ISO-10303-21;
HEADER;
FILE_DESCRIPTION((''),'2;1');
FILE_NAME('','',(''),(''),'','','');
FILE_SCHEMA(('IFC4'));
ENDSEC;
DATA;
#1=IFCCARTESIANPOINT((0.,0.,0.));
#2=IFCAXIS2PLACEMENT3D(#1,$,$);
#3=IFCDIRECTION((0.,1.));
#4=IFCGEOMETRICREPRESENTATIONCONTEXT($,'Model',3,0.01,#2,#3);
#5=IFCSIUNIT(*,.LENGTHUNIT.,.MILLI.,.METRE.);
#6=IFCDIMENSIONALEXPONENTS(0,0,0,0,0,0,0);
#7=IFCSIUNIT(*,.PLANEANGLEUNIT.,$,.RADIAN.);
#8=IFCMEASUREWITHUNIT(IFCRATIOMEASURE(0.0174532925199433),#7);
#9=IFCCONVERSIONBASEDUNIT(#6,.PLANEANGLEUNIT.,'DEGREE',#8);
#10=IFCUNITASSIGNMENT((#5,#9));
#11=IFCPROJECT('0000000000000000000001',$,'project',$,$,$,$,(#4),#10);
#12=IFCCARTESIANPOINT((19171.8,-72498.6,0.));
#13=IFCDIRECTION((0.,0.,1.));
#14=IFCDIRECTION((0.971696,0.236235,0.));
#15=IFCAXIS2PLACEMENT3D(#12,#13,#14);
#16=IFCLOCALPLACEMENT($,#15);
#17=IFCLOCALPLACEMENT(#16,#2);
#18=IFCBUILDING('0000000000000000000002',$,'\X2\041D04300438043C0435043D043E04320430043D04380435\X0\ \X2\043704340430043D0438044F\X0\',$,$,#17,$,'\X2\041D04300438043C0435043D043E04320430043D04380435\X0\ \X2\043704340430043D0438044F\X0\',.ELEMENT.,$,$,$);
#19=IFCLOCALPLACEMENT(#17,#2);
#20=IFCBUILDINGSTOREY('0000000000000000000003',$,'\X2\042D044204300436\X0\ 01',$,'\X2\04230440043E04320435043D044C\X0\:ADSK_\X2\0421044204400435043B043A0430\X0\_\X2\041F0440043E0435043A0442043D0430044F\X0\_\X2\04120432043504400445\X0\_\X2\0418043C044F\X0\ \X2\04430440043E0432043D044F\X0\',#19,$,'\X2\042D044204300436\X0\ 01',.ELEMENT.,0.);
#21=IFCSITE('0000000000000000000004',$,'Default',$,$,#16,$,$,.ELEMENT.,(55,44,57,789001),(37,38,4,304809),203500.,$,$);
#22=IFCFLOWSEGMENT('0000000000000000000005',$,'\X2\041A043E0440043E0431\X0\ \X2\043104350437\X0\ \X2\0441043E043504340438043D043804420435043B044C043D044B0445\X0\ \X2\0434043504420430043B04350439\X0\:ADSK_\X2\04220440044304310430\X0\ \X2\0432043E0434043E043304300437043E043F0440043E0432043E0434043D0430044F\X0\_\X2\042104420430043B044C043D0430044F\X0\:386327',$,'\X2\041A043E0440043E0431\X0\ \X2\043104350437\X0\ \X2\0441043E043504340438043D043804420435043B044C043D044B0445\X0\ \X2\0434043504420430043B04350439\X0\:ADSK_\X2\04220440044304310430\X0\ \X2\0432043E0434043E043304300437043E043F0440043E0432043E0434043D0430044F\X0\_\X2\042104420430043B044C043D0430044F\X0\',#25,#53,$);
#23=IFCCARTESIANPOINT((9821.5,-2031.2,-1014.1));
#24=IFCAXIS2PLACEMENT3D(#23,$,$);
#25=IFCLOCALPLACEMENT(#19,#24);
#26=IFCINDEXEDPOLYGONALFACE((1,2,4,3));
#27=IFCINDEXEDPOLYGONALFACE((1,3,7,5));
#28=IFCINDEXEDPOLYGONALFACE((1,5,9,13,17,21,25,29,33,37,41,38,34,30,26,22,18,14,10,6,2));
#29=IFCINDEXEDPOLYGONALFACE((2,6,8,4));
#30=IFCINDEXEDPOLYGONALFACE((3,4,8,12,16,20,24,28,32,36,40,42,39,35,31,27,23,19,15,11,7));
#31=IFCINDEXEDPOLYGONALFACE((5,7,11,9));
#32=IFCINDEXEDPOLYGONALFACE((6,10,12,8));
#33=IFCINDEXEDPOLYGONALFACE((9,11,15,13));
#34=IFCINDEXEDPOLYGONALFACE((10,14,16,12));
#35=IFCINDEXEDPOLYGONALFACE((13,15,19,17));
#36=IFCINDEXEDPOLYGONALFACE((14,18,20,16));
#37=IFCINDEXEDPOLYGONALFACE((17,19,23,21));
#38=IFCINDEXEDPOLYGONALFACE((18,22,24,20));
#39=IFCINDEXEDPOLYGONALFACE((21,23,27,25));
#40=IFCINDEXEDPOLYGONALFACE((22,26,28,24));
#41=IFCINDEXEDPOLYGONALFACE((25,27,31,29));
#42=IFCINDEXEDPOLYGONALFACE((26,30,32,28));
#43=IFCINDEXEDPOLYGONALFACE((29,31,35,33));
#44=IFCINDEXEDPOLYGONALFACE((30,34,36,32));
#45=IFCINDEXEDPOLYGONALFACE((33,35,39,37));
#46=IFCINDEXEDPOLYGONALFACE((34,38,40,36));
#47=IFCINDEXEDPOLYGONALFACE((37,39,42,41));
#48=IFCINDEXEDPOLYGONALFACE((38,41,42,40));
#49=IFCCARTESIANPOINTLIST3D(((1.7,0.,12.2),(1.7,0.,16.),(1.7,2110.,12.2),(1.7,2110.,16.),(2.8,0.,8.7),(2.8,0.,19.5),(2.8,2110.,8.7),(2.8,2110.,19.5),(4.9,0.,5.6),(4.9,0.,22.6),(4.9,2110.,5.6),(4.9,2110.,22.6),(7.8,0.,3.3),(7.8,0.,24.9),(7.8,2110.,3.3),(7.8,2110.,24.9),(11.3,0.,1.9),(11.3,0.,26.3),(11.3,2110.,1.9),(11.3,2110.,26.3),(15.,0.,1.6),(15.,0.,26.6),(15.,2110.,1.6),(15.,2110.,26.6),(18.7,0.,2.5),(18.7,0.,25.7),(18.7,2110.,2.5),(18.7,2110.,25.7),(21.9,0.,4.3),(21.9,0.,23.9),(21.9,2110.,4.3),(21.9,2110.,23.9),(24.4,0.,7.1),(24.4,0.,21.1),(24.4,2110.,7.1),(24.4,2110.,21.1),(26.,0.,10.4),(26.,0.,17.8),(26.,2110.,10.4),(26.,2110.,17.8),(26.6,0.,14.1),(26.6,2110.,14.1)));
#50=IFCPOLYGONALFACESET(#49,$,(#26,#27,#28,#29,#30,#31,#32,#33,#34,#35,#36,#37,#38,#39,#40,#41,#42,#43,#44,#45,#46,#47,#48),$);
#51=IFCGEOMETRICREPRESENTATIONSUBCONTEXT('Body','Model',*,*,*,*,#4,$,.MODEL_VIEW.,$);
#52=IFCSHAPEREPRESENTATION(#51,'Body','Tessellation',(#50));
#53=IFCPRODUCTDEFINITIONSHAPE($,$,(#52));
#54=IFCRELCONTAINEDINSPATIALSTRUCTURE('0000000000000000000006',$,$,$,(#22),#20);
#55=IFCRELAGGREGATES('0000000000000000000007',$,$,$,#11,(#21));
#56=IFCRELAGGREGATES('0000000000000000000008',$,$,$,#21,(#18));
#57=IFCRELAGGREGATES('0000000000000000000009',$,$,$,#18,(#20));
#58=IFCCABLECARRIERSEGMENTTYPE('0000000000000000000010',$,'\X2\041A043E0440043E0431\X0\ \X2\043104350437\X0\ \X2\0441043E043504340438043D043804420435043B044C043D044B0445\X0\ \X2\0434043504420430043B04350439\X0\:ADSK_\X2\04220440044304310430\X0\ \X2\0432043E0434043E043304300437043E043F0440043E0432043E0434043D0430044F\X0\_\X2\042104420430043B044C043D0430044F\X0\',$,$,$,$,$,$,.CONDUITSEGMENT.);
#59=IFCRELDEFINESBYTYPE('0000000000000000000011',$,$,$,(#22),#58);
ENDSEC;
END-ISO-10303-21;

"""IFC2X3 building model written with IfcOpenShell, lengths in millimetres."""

from ifc_helpers import new_model, entity, si_unit, converted_unit, direction, frame, origin, origin_2d_with_axis, place, context, subcontext, project, spatial, circle, extrude, type_object, element, save


model = new_model("IFC2X3")

# Units and contexts
model_context = context("Model", 3, precision=0.01, world=origin(), true_north=direction((0.0, 1.0)))
body_context = subcontext(model_context, "Body", "Model", "MODEL_VIEW")
ifc_project = project(units=[si_unit("LENGTHUNIT", "METRE", prefix="MILLI"), converted_unit("PLANEANGLEUNIT", "DEGREE", entity("IfcRatioMeasure", 0.0174532925199433), si_unit("PLANEANGLEUNIT", "RADIAN"), dimensions=[0, 0, 0, 0, 0, 0, 0])], contexts=[model_context])

# Site, building, storey
site_placement = place(None, frame((19171.8, -72498.6, 0.0), z_axis=(0.0, 0.0, 1.0), x_axis=(0.971696, 0.236235, 0.0)))
site = spatial("IfcSite", under=ifc_project, at=site_placement, Name="Default", CompositionType="ELEMENT", RefLatitude=(55, 44, 57, 789001), RefLongitude=(37, 38, 4, 304809), RefElevation=203500.0)
building_placement = place(site_placement, origin())
building = spatial("IfcBuilding", under=site, at=building_placement, Name="Наименование здания", LongName="Наименование здания", CompositionType="ELEMENT")
storey_placement = place(building_placement, origin())
storey = spatial("IfcBuildingStorey", under=building, at=storey_placement, Name="Этаж 01", ObjectType="Уровень:ADSK_Стрелка_Проектная_Вверх_Имя уровня", LongName="Этаж 01", CompositionType="ELEMENT", Elevation=0.0)

# Flow segment
cable_carrier_segment_type_1 = type_object("IfcCableCarrierSegmentType", Name="Короб без соединительных деталей:ADSK_Труба водогазопроводная_Стальная", PredefinedType="CONDUITSEGMENT")
flow_segment_1_placement = place(storey_placement, frame((9821.5, -2031.2, -1014.1)))
element("IfcFlowSegment", 1, at=flow_segment_1_placement, inside=storey, type_object=cable_carrier_segment_type_1, Name="Короб без соединительных деталей:ADSK_Труба водогазопроводная_Стальная:386327", ObjectType="Короб без соединительных деталей:ADSK_Труба водогазопроводная_Стальная", context=body_context, shape_type="SweptSolid", body=[
    extrude(circle(Radius=12.5, at=origin_2d_with_axis()), frame((14.1, 0.0, 14.1), z_axis=(0.0, 1.0, 0.0), x_axis=(1.0, 0.0, 0.0)), (0.0, 0.0, 1.0), 2110.0),
])

save(model, "model.ifc")
